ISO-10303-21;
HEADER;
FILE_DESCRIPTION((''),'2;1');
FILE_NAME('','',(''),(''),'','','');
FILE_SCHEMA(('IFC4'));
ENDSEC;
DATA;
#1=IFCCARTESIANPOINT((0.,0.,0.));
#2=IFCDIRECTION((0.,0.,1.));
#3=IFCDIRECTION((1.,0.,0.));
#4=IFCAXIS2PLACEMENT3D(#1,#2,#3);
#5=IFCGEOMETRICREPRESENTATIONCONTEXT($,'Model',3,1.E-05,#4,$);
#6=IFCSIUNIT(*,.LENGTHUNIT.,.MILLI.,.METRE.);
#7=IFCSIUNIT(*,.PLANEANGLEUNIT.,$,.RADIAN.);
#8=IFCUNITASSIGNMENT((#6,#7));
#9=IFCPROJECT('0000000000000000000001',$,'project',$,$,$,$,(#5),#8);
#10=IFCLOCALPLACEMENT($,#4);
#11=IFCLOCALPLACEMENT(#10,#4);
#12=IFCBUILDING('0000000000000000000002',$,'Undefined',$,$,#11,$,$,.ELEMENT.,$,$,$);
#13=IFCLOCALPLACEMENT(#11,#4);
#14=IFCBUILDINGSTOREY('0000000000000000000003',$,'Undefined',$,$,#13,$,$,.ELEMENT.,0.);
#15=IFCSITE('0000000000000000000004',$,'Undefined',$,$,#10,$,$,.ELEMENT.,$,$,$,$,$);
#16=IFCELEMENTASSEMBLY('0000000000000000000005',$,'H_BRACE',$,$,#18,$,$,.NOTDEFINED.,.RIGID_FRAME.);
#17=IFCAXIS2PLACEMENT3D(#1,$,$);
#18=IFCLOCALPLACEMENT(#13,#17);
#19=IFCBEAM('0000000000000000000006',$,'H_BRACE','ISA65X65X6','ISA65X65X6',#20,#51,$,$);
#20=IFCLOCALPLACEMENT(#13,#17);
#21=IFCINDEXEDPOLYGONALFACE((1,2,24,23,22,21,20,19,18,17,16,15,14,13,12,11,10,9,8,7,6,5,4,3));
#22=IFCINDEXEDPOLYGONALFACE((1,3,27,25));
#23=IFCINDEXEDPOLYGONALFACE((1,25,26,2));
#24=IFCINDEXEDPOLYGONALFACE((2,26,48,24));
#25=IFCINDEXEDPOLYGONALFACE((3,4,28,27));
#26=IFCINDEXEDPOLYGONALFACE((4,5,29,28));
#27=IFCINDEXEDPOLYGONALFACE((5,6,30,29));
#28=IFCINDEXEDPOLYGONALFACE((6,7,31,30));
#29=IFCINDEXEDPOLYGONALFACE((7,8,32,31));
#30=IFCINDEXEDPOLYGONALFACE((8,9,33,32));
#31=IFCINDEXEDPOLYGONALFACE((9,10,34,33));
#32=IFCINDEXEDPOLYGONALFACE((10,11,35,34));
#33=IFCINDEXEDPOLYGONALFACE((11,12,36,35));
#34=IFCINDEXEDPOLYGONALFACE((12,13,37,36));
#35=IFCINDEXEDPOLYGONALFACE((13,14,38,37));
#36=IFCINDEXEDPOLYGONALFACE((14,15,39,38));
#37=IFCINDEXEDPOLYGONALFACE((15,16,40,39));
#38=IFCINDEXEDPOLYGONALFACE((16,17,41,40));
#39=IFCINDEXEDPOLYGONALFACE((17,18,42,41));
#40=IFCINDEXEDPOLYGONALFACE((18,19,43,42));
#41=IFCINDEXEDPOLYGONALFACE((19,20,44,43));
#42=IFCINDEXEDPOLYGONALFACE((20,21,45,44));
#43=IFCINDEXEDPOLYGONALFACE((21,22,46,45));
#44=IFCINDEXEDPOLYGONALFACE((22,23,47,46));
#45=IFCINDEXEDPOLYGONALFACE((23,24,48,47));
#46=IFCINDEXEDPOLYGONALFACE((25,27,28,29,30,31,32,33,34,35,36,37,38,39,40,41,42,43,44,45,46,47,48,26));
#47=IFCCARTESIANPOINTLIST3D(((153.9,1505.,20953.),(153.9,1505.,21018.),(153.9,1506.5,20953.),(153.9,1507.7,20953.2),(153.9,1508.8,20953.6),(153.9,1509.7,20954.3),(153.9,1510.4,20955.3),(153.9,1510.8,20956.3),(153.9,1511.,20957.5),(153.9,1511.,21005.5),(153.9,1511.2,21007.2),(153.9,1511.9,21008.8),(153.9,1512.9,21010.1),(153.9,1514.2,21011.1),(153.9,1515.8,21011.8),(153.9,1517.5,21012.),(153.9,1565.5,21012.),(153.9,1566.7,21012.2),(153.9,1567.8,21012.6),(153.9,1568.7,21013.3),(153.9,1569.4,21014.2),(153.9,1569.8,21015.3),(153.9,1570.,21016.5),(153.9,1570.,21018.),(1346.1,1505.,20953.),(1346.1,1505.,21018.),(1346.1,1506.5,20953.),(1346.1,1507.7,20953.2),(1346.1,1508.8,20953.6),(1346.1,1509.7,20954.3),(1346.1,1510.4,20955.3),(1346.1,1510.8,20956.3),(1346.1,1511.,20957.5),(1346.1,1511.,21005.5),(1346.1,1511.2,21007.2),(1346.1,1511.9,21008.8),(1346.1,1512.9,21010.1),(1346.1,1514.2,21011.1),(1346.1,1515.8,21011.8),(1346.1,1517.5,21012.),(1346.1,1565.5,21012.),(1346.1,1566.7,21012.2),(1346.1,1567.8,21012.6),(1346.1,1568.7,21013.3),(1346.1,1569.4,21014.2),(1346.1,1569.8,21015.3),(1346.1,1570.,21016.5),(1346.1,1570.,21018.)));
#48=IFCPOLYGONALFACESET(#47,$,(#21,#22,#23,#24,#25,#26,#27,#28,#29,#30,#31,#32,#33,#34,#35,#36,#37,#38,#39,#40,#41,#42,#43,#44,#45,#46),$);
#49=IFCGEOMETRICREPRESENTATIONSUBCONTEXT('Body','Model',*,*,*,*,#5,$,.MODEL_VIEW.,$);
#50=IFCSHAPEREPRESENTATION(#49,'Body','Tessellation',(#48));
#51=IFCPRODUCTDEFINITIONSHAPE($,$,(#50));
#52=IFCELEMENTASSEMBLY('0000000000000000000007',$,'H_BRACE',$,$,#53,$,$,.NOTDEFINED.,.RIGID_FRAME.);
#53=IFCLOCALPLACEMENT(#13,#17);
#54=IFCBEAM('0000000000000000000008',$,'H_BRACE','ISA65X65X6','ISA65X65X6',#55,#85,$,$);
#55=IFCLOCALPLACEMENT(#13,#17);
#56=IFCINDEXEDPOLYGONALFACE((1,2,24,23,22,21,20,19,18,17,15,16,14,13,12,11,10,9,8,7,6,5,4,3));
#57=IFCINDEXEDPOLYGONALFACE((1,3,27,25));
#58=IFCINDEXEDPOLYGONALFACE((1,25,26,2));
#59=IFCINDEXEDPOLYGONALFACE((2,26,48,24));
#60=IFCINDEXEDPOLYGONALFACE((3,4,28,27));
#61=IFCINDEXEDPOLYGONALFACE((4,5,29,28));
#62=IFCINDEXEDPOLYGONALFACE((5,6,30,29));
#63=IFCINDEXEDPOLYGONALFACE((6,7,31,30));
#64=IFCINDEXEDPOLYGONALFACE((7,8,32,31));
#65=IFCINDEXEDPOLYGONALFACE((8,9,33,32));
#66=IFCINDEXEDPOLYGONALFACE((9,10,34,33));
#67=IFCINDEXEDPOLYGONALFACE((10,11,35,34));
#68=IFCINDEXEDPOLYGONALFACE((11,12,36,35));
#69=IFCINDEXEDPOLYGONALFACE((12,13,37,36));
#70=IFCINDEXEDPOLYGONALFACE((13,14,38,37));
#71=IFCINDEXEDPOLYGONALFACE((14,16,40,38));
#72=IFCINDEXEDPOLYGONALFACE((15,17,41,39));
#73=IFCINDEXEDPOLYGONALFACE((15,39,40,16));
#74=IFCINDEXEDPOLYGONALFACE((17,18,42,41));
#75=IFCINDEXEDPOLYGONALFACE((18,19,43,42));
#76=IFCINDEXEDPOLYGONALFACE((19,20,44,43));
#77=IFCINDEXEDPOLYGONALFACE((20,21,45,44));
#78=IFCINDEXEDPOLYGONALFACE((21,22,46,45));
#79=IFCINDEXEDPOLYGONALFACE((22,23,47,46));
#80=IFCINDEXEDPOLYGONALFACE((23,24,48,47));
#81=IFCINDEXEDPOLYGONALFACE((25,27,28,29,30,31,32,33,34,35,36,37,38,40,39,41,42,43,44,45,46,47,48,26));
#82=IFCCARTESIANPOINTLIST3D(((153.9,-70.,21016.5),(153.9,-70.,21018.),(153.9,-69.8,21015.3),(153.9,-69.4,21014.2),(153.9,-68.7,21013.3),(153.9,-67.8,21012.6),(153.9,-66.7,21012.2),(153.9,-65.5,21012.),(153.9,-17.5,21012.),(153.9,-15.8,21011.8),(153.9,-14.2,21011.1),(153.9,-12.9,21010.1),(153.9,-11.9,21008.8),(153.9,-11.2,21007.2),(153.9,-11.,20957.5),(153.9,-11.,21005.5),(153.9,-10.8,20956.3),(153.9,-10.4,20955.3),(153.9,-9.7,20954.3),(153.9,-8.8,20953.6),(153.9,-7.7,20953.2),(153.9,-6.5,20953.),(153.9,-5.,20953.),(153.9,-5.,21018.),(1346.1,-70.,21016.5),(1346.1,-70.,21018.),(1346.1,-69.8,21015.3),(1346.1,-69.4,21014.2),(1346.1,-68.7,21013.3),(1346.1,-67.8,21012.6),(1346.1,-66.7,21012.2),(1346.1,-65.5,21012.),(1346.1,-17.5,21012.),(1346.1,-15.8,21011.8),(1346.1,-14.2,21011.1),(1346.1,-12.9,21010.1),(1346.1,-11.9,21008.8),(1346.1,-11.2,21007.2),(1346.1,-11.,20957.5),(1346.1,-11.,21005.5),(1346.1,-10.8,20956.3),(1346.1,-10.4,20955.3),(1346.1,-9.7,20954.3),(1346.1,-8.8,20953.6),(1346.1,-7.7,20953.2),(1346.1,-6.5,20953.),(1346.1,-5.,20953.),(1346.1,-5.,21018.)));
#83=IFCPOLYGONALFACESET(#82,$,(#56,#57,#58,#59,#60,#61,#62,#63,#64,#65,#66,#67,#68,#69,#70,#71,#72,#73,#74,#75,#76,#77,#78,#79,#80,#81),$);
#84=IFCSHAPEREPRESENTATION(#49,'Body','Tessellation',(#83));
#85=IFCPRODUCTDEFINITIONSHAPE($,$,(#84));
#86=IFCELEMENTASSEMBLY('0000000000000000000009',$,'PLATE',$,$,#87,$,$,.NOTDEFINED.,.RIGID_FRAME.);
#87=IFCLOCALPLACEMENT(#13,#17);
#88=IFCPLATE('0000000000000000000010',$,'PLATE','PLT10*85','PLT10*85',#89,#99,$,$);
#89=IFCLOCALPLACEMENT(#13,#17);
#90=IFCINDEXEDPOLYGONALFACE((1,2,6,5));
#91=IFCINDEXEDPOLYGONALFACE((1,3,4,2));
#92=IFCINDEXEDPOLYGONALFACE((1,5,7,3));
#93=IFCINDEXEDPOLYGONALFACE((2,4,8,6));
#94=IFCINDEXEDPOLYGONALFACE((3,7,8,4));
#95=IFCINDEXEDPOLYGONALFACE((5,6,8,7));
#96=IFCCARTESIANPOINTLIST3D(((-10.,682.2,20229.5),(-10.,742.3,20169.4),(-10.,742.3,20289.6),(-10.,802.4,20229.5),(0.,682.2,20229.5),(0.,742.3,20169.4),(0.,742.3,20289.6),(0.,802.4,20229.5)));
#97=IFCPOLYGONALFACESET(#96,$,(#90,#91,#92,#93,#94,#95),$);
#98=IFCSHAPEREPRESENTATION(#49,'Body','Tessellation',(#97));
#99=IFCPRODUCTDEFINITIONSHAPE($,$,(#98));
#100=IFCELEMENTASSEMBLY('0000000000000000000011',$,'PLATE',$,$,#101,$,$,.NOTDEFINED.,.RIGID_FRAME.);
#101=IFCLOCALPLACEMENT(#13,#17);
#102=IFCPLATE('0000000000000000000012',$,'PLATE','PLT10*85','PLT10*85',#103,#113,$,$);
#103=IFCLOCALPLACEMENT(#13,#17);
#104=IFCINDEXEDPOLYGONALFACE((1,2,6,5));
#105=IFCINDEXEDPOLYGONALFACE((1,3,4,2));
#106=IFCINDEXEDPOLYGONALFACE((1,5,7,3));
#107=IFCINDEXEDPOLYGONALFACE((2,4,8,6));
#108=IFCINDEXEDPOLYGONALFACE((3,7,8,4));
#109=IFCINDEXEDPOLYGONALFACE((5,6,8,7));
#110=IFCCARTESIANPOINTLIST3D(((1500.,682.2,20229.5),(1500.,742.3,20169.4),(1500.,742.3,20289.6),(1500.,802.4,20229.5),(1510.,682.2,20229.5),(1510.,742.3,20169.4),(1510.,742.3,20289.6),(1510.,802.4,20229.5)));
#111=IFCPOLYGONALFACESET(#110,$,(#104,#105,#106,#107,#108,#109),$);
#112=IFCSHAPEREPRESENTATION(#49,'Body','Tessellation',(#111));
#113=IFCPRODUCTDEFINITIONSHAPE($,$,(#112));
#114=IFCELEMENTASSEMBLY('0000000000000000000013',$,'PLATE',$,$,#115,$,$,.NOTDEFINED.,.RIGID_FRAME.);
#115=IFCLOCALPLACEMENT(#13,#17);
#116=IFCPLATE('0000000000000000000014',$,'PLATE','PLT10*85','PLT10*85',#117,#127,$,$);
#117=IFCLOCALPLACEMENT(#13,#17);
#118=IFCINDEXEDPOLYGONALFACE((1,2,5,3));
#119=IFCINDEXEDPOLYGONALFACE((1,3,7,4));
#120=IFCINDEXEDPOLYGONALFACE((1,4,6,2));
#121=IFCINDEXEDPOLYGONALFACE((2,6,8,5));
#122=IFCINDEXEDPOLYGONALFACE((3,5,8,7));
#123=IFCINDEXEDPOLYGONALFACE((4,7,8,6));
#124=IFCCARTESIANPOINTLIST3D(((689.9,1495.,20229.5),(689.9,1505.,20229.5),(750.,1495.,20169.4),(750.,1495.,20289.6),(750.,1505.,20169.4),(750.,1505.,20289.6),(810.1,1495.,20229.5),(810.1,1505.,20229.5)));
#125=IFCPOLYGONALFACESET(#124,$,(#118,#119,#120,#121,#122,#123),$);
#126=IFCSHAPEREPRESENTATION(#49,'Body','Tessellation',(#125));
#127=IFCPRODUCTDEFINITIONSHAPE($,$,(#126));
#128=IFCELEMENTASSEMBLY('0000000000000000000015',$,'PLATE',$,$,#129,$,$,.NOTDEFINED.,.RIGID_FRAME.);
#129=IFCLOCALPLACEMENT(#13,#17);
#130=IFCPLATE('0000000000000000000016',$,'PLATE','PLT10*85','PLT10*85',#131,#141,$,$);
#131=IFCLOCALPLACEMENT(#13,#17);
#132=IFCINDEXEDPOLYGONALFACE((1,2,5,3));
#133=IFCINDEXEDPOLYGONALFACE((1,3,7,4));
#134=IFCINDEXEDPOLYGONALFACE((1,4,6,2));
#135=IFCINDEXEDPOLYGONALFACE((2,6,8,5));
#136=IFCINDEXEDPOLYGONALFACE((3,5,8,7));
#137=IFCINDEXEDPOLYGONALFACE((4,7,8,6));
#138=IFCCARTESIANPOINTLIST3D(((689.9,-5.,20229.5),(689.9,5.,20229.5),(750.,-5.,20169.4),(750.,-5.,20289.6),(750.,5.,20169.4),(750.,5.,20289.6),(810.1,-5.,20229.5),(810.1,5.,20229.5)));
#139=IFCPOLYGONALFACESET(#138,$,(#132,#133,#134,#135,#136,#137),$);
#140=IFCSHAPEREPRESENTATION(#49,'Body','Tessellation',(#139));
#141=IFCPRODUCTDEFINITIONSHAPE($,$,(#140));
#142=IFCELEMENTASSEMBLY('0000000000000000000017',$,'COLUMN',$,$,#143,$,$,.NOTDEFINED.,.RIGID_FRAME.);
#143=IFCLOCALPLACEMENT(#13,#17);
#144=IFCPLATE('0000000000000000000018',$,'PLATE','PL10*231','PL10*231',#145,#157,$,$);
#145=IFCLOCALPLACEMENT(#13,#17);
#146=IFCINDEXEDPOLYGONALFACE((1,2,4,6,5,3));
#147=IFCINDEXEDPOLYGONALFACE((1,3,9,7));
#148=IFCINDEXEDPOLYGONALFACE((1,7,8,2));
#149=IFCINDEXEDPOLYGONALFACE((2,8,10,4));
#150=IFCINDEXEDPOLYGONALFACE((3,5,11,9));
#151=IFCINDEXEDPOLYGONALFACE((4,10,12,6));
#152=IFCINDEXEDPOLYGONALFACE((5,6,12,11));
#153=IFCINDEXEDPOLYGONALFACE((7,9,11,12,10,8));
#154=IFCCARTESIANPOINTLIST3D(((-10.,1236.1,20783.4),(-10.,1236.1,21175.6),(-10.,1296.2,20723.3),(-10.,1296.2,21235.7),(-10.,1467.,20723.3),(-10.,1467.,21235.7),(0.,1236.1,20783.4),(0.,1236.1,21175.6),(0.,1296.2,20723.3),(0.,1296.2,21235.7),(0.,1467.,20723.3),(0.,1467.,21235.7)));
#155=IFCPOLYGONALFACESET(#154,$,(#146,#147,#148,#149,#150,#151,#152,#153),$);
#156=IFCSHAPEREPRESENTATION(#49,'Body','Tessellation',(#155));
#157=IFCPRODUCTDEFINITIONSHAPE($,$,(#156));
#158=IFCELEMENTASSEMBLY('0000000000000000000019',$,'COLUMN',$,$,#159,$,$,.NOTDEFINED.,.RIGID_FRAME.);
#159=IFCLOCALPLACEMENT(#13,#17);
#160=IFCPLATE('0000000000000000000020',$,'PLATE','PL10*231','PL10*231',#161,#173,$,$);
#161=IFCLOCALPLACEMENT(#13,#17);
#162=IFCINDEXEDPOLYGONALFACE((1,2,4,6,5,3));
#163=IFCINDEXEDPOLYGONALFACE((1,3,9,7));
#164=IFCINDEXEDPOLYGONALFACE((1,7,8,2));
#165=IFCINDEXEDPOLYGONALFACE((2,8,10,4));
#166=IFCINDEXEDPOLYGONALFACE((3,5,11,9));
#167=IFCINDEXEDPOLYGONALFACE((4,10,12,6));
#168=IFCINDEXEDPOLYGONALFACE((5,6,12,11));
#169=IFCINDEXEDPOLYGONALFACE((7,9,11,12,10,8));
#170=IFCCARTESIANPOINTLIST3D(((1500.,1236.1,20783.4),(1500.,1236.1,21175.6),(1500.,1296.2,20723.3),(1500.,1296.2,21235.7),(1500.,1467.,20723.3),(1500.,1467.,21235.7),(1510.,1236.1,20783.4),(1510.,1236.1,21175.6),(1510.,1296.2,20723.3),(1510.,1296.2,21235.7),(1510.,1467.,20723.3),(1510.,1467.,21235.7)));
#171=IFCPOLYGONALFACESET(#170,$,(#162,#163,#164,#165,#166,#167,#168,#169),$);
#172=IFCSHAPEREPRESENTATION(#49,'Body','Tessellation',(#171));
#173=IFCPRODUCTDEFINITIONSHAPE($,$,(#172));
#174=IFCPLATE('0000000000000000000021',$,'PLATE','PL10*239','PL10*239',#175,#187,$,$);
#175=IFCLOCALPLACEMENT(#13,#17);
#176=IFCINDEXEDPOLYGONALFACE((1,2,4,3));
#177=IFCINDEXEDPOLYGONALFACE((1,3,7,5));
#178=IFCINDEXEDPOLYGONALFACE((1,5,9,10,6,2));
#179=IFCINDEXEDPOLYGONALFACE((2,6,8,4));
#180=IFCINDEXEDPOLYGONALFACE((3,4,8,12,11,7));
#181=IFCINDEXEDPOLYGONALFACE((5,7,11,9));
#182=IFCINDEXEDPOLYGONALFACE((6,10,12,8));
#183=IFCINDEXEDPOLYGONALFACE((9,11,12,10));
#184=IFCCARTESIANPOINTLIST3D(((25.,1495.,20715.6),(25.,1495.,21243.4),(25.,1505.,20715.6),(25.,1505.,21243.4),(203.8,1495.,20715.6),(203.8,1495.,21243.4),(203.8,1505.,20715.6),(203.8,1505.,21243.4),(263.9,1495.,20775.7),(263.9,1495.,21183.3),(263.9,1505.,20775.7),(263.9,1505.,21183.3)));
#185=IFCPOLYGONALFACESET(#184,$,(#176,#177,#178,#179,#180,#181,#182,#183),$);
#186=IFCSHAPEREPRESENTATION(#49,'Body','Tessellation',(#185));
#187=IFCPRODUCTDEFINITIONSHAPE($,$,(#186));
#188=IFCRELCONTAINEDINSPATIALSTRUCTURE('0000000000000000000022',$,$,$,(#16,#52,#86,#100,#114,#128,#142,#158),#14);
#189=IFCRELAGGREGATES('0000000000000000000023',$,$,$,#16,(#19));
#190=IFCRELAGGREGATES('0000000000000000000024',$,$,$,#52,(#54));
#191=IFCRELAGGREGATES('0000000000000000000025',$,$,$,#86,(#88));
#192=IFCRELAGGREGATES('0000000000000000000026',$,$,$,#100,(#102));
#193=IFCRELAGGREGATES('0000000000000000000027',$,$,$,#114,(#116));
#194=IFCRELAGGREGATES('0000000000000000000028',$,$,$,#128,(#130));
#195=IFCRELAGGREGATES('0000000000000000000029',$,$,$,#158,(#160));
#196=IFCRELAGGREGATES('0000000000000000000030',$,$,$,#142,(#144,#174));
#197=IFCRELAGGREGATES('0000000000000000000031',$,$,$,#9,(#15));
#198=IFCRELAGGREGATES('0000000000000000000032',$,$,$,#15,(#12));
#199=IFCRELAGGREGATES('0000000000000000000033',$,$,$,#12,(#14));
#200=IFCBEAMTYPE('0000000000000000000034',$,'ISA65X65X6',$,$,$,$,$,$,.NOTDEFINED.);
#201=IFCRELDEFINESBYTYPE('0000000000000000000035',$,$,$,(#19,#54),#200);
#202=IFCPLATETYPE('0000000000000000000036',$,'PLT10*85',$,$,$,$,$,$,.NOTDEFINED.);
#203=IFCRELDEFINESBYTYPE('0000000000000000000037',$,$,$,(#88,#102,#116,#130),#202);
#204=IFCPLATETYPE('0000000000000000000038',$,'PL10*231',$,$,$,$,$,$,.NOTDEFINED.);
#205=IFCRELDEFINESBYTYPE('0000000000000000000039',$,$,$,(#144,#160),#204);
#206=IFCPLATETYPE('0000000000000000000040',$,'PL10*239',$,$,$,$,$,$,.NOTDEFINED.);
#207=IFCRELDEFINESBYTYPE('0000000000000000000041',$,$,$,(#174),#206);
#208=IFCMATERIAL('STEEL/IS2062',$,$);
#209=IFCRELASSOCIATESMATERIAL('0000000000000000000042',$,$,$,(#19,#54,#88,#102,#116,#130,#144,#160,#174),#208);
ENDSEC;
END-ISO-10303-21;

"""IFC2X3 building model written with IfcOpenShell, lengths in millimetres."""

from ifc_helpers import new_model, si_unit, frame, origin_with_axes, origin_2d_with_axis, place, context, subcontext, project, spatial, polyline, l_section, outline, extrude, clip, halfspace, material, type_object, element, aggregate, save


model = new_model("IFC2X3")

# Units and contexts
model_context = context("Model", 3, precision=1e-05, world=origin_with_axes())
body_context = subcontext(model_context, "Body", "Model", "MODEL_VIEW")
ifc_project = project(units=[si_unit("LENGTHUNIT", "METRE", prefix="MILLI"), si_unit("PLANEANGLEUNIT", "RADIAN")], contexts=[model_context])

# Site, building, storey
site_placement = place(None, origin_with_axes())
site = spatial("IfcSite", under=ifc_project, at=site_placement, Name="Undefined", CompositionType="ELEMENT")
building_placement = place(site_placement, origin_with_axes())
building = spatial("IfcBuilding", under=site, at=building_placement, Name="Undefined", CompositionType="ELEMENT")
storey_placement = place(building_placement, origin_with_axes())
storey = spatial("IfcBuildingStorey", under=building, at=storey_placement, Name="Undefined", CompositionType="ELEMENT", Elevation=0.0)

# Shared definitions
ifc_material = material(Name="STEEL/IS2062")

# Element assemblies, beams
beam_type_1 = type_object("IfcBeamType", Name="ISA65X65X6", PredefinedType="NOTDEFINED")
assembly_1_placement = place(storey_placement, origin_with_axes())
assembly_1 = element("IfcElementAssembly", 1, at=assembly_1_placement, inside=storey, Name="H_BRACE", AssemblyPlace="NOTDEFINED", PredefinedType="RIGID_FRAME")
beam_1_placement = place(assembly_1_placement, frame((1500.0, 1537.5, 20985.5), z_axis=(0.0, 1.0, 0.0), x_axis=(-1.0, 0.0, 0.0)))
beam_1 = element("IfcBeam", 2, at=beam_1_placement, type_object=beam_type_1, material=ifc_material, Name="H_BRACE", Description="ISA65X65X6", ObjectType="ISA65X65X6", context=body_context, shape_type="Clipping", body=[
    clip(clip(extrude(l_section(Depth=65.0, Width=65.0, Thickness=6.0, FilletRadius=6.5, EdgeRadius=4.5, at=origin_2d_with_axis()), frame((1500.0, 0.0, 0.0), z_axis=(-1.0, 0.0, 0.0), x_axis=(0.0, -1.0, 0.0)), (0.0, 0.0, 1.0), 1500.0), halfspace(frame((1346.1, 0.0, -42.5), z_axis=(-1.0, 0.0, 0.0), x_axis=(0.0, 1.0, 0.0)), True)), halfspace(frame((153.9, 0.0, -42.5), z_axis=(1.0, 0.0, 0.0), x_axis=(0.0, -1.0, 0.0)), True)),
])
aggregate(assembly_1, [beam_1])
assembly_2_placement = place(storey_placement, origin_with_axes())
assembly_2 = element("IfcElementAssembly", 3, at=assembly_2_placement, inside=storey, Name="H_BRACE", AssemblyPlace="NOTDEFINED", PredefinedType="RIGID_FRAME")
beam_2_placement = place(assembly_2_placement, frame((0.0, -37.5, 20985.5), z_axis=(0.0, -1.0, 0.0), x_axis=(1.0, 0.0, 0.0)))
beam_2 = element("IfcBeam", 4, at=beam_2_placement, type_object=beam_type_1, material=ifc_material, Name="H_BRACE", Description="ISA65X65X6", ObjectType="ISA65X65X6", context=body_context, shape_type="Clipping", body=[
    clip(clip(extrude(l_section(Depth=65.0, Width=65.0, Thickness=6.0, FilletRadius=6.5, EdgeRadius=4.5, at=origin_2d_with_axis()), frame((1500.0, 0.0, 0.0), z_axis=(-1.0, 0.0, 0.0), x_axis=(0.0, -1.0, 0.0)), (0.0, 0.0, 1.0), 1500.0), halfspace(frame((1346.1, 0.0, -32.5), z_axis=(-1.0, 0.0, 0.0), x_axis=(0.0, -1.0, 0.0)), True)), halfspace(frame((153.9, 0.0, -32.5), z_axis=(1.0, 0.0, 0.0), x_axis=(0.0, 1.0, 0.0)), True)),
])
aggregate(assembly_2, [beam_2])

# Element assemblies, plates
assembly_3_placement = place(storey_placement, origin_with_axes())
assembly_3 = element("IfcElementAssembly", 5, at=assembly_3_placement, inside=storey, Name="PLATE", AssemblyPlace="NOTDEFINED", PredefinedType="RIGID_FRAME")
plate_type_1 = type_object("IfcPlateType", Name="PLT10*85", PredefinedType="NOTDEFINED")
plate_1_placement = place(assembly_3_placement, frame((-5.0, 742.3, 20289.6), z_axis=(1.0, 0.0, 0.0), x_axis=(0.0, -0.707107, -0.707107)))
plate_1 = element("IfcPlate", 6, at=plate_1_placement, type_object=plate_type_1, material=ifc_material, Name="PLATE", Description="PLT10*85", ObjectType="PLT10*85", context=body_context, shape_type="SweptSolid", body=[
    extrude(outline(polyline([(0.0, 0.0), (85.0, 0.0), (85.0, 85.0), (0.0, 85.0), (0.0, 0.0)])), frame((0.0, 0.0, -5.0), z_axis=(0.0, 0.0, 1.0), x_axis=(1.0, 0.0, 0.0)), (0.0, 0.0, 1.0), 10.0),
])
aggregate(assembly_3, [plate_1])
assembly_4_placement = place(storey_placement, origin_with_axes())
assembly_4 = element("IfcElementAssembly", 7, at=assembly_4_placement, inside=storey, Name="PLATE", AssemblyPlace="NOTDEFINED", PredefinedType="RIGID_FRAME")
plate_2_placement = place(assembly_4_placement, frame((1505.0, 742.3, 20289.6), z_axis=(1.0, 0.0, 0.0), x_axis=(0.0, -0.707107, -0.707107)))
plate_2 = element("IfcPlate", 8, at=plate_2_placement, type_object=plate_type_1, material=ifc_material, Name="PLATE", Description="PLT10*85", ObjectType="PLT10*85", context=body_context, shape_type="SweptSolid", body=[
    extrude(outline(polyline([(0.0, 0.0), (85.0, 0.0), (85.0, 85.0), (0.0, 85.0), (0.0, 0.0)])), frame((0.0, 0.0, -5.0), z_axis=(0.0, 0.0, 1.0), x_axis=(1.0, 0.0, 0.0)), (0.0, 0.0, 1.0), 10.0),
])
aggregate(assembly_4, [plate_2])
assembly_5_placement = place(storey_placement, origin_with_axes())
assembly_5 = element("IfcElementAssembly", 9, at=assembly_5_placement, inside=storey, Name="PLATE", AssemblyPlace="NOTDEFINED", PredefinedType="RIGID_FRAME")
plate_3_placement = place(assembly_5_placement, frame((750.0, 1500.0, 20289.6), z_axis=(0.0, -1.0, 0.0), x_axis=(-0.707107, 0.0, -0.707107)))
plate_3 = element("IfcPlate", 10, at=plate_3_placement, type_object=plate_type_1, material=ifc_material, Name="PLATE", Description="PLT10*85", ObjectType="PLT10*85", context=body_context, shape_type="SweptSolid", body=[
    extrude(outline(polyline([(0.0, 0.0), (85.0, 0.0), (85.0, 85.0), (0.0, 85.0), (0.0, 0.0)])), frame((0.0, 0.0, -5.0), z_axis=(0.0, 0.0, 1.0), x_axis=(1.0, 0.0, 0.0)), (0.0, 0.0, 1.0), 10.0),
])
aggregate(assembly_5, [plate_3])
assembly_6_placement = place(storey_placement, origin_with_axes())
assembly_6 = element("IfcElementAssembly", 11, at=assembly_6_placement, inside=storey, Name="PLATE", AssemblyPlace="NOTDEFINED", PredefinedType="RIGID_FRAME")
plate_4_placement = place(assembly_6_placement, frame((750.0, 0.0, 20289.6), z_axis=(0.0, -1.0, 0.0), x_axis=(-0.707107, 0.0, -0.707107)))
plate_4 = element("IfcPlate", 12, at=plate_4_placement, type_object=plate_type_1, material=ifc_material, Name="PLATE", Description="PLT10*85", ObjectType="PLT10*85", context=body_context, shape_type="SweptSolid", body=[
    extrude(outline(polyline([(0.0, 0.0), (85.0, 0.0), (85.0, 85.0), (0.0, 85.0), (0.0, 0.0)])), frame((0.0, 0.0, -5.0), z_axis=(0.0, 0.0, 1.0), x_axis=(1.0, 0.0, 0.0)), (0.0, 0.0, 1.0), 10.0),
])
aggregate(assembly_6, [plate_4])
assembly_7_placement = place(storey_placement, origin_with_axes())
assembly_7 = element("IfcElementAssembly", 13, at=assembly_7_placement, inside=storey, Name="COLUMN", AssemblyPlace="NOTDEFINED", PredefinedType="RIGID_FRAME")
plate_type_2 = type_object("IfcPlateType", Name="PL10*231", PredefinedType="NOTDEFINED")
plate_5_placement = place(assembly_7_placement, frame((-5.0, 1467.0, 20723.3), z_axis=(1.0, 0.0, 0.0), x_axis=(0.0, 0.0, 1.0)))
plate_5 = element("IfcPlate", 14, at=plate_5_placement, type_object=plate_type_2, material=ifc_material, Name="PLATE", Description="PL10*231", ObjectType="PL10*231", context=body_context, shape_type="SweptSolid", body=[
    extrude(outline(polyline([(0.0, 0.0), (512.3, 0.0), (512.3, 170.8), (452.2, 230.9), (60.1, 230.9), (0.0, 170.8), (0.0, 0.0)])), frame((0.0, 0.0, -5.0), z_axis=(0.0, 0.0, 1.0), x_axis=(1.0, 0.0, 0.0)), (0.0, 0.0, 1.0), 10.0),
])
assembly_8_placement = place(storey_placement, origin_with_axes())
assembly_8 = element("IfcElementAssembly", 15, at=assembly_8_placement, inside=storey, Name="COLUMN", AssemblyPlace="NOTDEFINED", PredefinedType="RIGID_FRAME")
plate_6_placement = place(assembly_8_placement, frame((1505.0, 1467.0, 20723.3), z_axis=(1.0, 0.0, 0.0), x_axis=(0.0, 0.0, 1.0)))
plate_6 = element("IfcPlate", 16, at=plate_6_placement, type_object=plate_type_2, material=ifc_material, Name="PLATE", Description="PL10*231", ObjectType="PL10*231", context=body_context, shape_type="SweptSolid", body=[
    extrude(outline(polyline([(0.0, 0.0), (512.3, 0.0), (512.3, 170.8), (452.2, 230.9), (60.1, 230.9), (0.0, 170.8), (0.0, 0.0)])), frame((0.0, 0.0, -5.0), z_axis=(0.0, 0.0, 1.0), x_axis=(1.0, 0.0, 0.0)), (0.0, 0.0, 1.0), 10.0),
])
aggregate(assembly_8, [plate_6])

# Plate
plate_type_3 = type_object("IfcPlateType", Name="PL10*239", PredefinedType="NOTDEFINED")
plate_7_placement = place(assembly_7_placement, frame((25.0, 1500.0, 20715.6), z_axis=(0.0, 1.0, 0.0), x_axis=(0.0, 0.0, 1.0)))
plate_7 = element("IfcPlate", 17, at=plate_7_placement, type_object=plate_type_3, material=ifc_material, Name="PLATE", Description="PL10*239", ObjectType="PL10*239", context=body_context, shape_type="SweptSolid", body=[
    extrude(outline(polyline([(0.0, 0.0), (527.8, 0.0), (527.8, 178.8), (467.7, 238.9), (60.1, 238.9), (0.0, 178.8), (0.0, 0.0)])), frame((0.0, 0.0, -5.0), z_axis=(0.0, 0.0, 1.0), x_axis=(1.0, 0.0, 0.0)), (0.0, 0.0, 1.0), 10.0),
])
aggregate(assembly_7, [plate_5, plate_7])

save(model, "model.ifc")
